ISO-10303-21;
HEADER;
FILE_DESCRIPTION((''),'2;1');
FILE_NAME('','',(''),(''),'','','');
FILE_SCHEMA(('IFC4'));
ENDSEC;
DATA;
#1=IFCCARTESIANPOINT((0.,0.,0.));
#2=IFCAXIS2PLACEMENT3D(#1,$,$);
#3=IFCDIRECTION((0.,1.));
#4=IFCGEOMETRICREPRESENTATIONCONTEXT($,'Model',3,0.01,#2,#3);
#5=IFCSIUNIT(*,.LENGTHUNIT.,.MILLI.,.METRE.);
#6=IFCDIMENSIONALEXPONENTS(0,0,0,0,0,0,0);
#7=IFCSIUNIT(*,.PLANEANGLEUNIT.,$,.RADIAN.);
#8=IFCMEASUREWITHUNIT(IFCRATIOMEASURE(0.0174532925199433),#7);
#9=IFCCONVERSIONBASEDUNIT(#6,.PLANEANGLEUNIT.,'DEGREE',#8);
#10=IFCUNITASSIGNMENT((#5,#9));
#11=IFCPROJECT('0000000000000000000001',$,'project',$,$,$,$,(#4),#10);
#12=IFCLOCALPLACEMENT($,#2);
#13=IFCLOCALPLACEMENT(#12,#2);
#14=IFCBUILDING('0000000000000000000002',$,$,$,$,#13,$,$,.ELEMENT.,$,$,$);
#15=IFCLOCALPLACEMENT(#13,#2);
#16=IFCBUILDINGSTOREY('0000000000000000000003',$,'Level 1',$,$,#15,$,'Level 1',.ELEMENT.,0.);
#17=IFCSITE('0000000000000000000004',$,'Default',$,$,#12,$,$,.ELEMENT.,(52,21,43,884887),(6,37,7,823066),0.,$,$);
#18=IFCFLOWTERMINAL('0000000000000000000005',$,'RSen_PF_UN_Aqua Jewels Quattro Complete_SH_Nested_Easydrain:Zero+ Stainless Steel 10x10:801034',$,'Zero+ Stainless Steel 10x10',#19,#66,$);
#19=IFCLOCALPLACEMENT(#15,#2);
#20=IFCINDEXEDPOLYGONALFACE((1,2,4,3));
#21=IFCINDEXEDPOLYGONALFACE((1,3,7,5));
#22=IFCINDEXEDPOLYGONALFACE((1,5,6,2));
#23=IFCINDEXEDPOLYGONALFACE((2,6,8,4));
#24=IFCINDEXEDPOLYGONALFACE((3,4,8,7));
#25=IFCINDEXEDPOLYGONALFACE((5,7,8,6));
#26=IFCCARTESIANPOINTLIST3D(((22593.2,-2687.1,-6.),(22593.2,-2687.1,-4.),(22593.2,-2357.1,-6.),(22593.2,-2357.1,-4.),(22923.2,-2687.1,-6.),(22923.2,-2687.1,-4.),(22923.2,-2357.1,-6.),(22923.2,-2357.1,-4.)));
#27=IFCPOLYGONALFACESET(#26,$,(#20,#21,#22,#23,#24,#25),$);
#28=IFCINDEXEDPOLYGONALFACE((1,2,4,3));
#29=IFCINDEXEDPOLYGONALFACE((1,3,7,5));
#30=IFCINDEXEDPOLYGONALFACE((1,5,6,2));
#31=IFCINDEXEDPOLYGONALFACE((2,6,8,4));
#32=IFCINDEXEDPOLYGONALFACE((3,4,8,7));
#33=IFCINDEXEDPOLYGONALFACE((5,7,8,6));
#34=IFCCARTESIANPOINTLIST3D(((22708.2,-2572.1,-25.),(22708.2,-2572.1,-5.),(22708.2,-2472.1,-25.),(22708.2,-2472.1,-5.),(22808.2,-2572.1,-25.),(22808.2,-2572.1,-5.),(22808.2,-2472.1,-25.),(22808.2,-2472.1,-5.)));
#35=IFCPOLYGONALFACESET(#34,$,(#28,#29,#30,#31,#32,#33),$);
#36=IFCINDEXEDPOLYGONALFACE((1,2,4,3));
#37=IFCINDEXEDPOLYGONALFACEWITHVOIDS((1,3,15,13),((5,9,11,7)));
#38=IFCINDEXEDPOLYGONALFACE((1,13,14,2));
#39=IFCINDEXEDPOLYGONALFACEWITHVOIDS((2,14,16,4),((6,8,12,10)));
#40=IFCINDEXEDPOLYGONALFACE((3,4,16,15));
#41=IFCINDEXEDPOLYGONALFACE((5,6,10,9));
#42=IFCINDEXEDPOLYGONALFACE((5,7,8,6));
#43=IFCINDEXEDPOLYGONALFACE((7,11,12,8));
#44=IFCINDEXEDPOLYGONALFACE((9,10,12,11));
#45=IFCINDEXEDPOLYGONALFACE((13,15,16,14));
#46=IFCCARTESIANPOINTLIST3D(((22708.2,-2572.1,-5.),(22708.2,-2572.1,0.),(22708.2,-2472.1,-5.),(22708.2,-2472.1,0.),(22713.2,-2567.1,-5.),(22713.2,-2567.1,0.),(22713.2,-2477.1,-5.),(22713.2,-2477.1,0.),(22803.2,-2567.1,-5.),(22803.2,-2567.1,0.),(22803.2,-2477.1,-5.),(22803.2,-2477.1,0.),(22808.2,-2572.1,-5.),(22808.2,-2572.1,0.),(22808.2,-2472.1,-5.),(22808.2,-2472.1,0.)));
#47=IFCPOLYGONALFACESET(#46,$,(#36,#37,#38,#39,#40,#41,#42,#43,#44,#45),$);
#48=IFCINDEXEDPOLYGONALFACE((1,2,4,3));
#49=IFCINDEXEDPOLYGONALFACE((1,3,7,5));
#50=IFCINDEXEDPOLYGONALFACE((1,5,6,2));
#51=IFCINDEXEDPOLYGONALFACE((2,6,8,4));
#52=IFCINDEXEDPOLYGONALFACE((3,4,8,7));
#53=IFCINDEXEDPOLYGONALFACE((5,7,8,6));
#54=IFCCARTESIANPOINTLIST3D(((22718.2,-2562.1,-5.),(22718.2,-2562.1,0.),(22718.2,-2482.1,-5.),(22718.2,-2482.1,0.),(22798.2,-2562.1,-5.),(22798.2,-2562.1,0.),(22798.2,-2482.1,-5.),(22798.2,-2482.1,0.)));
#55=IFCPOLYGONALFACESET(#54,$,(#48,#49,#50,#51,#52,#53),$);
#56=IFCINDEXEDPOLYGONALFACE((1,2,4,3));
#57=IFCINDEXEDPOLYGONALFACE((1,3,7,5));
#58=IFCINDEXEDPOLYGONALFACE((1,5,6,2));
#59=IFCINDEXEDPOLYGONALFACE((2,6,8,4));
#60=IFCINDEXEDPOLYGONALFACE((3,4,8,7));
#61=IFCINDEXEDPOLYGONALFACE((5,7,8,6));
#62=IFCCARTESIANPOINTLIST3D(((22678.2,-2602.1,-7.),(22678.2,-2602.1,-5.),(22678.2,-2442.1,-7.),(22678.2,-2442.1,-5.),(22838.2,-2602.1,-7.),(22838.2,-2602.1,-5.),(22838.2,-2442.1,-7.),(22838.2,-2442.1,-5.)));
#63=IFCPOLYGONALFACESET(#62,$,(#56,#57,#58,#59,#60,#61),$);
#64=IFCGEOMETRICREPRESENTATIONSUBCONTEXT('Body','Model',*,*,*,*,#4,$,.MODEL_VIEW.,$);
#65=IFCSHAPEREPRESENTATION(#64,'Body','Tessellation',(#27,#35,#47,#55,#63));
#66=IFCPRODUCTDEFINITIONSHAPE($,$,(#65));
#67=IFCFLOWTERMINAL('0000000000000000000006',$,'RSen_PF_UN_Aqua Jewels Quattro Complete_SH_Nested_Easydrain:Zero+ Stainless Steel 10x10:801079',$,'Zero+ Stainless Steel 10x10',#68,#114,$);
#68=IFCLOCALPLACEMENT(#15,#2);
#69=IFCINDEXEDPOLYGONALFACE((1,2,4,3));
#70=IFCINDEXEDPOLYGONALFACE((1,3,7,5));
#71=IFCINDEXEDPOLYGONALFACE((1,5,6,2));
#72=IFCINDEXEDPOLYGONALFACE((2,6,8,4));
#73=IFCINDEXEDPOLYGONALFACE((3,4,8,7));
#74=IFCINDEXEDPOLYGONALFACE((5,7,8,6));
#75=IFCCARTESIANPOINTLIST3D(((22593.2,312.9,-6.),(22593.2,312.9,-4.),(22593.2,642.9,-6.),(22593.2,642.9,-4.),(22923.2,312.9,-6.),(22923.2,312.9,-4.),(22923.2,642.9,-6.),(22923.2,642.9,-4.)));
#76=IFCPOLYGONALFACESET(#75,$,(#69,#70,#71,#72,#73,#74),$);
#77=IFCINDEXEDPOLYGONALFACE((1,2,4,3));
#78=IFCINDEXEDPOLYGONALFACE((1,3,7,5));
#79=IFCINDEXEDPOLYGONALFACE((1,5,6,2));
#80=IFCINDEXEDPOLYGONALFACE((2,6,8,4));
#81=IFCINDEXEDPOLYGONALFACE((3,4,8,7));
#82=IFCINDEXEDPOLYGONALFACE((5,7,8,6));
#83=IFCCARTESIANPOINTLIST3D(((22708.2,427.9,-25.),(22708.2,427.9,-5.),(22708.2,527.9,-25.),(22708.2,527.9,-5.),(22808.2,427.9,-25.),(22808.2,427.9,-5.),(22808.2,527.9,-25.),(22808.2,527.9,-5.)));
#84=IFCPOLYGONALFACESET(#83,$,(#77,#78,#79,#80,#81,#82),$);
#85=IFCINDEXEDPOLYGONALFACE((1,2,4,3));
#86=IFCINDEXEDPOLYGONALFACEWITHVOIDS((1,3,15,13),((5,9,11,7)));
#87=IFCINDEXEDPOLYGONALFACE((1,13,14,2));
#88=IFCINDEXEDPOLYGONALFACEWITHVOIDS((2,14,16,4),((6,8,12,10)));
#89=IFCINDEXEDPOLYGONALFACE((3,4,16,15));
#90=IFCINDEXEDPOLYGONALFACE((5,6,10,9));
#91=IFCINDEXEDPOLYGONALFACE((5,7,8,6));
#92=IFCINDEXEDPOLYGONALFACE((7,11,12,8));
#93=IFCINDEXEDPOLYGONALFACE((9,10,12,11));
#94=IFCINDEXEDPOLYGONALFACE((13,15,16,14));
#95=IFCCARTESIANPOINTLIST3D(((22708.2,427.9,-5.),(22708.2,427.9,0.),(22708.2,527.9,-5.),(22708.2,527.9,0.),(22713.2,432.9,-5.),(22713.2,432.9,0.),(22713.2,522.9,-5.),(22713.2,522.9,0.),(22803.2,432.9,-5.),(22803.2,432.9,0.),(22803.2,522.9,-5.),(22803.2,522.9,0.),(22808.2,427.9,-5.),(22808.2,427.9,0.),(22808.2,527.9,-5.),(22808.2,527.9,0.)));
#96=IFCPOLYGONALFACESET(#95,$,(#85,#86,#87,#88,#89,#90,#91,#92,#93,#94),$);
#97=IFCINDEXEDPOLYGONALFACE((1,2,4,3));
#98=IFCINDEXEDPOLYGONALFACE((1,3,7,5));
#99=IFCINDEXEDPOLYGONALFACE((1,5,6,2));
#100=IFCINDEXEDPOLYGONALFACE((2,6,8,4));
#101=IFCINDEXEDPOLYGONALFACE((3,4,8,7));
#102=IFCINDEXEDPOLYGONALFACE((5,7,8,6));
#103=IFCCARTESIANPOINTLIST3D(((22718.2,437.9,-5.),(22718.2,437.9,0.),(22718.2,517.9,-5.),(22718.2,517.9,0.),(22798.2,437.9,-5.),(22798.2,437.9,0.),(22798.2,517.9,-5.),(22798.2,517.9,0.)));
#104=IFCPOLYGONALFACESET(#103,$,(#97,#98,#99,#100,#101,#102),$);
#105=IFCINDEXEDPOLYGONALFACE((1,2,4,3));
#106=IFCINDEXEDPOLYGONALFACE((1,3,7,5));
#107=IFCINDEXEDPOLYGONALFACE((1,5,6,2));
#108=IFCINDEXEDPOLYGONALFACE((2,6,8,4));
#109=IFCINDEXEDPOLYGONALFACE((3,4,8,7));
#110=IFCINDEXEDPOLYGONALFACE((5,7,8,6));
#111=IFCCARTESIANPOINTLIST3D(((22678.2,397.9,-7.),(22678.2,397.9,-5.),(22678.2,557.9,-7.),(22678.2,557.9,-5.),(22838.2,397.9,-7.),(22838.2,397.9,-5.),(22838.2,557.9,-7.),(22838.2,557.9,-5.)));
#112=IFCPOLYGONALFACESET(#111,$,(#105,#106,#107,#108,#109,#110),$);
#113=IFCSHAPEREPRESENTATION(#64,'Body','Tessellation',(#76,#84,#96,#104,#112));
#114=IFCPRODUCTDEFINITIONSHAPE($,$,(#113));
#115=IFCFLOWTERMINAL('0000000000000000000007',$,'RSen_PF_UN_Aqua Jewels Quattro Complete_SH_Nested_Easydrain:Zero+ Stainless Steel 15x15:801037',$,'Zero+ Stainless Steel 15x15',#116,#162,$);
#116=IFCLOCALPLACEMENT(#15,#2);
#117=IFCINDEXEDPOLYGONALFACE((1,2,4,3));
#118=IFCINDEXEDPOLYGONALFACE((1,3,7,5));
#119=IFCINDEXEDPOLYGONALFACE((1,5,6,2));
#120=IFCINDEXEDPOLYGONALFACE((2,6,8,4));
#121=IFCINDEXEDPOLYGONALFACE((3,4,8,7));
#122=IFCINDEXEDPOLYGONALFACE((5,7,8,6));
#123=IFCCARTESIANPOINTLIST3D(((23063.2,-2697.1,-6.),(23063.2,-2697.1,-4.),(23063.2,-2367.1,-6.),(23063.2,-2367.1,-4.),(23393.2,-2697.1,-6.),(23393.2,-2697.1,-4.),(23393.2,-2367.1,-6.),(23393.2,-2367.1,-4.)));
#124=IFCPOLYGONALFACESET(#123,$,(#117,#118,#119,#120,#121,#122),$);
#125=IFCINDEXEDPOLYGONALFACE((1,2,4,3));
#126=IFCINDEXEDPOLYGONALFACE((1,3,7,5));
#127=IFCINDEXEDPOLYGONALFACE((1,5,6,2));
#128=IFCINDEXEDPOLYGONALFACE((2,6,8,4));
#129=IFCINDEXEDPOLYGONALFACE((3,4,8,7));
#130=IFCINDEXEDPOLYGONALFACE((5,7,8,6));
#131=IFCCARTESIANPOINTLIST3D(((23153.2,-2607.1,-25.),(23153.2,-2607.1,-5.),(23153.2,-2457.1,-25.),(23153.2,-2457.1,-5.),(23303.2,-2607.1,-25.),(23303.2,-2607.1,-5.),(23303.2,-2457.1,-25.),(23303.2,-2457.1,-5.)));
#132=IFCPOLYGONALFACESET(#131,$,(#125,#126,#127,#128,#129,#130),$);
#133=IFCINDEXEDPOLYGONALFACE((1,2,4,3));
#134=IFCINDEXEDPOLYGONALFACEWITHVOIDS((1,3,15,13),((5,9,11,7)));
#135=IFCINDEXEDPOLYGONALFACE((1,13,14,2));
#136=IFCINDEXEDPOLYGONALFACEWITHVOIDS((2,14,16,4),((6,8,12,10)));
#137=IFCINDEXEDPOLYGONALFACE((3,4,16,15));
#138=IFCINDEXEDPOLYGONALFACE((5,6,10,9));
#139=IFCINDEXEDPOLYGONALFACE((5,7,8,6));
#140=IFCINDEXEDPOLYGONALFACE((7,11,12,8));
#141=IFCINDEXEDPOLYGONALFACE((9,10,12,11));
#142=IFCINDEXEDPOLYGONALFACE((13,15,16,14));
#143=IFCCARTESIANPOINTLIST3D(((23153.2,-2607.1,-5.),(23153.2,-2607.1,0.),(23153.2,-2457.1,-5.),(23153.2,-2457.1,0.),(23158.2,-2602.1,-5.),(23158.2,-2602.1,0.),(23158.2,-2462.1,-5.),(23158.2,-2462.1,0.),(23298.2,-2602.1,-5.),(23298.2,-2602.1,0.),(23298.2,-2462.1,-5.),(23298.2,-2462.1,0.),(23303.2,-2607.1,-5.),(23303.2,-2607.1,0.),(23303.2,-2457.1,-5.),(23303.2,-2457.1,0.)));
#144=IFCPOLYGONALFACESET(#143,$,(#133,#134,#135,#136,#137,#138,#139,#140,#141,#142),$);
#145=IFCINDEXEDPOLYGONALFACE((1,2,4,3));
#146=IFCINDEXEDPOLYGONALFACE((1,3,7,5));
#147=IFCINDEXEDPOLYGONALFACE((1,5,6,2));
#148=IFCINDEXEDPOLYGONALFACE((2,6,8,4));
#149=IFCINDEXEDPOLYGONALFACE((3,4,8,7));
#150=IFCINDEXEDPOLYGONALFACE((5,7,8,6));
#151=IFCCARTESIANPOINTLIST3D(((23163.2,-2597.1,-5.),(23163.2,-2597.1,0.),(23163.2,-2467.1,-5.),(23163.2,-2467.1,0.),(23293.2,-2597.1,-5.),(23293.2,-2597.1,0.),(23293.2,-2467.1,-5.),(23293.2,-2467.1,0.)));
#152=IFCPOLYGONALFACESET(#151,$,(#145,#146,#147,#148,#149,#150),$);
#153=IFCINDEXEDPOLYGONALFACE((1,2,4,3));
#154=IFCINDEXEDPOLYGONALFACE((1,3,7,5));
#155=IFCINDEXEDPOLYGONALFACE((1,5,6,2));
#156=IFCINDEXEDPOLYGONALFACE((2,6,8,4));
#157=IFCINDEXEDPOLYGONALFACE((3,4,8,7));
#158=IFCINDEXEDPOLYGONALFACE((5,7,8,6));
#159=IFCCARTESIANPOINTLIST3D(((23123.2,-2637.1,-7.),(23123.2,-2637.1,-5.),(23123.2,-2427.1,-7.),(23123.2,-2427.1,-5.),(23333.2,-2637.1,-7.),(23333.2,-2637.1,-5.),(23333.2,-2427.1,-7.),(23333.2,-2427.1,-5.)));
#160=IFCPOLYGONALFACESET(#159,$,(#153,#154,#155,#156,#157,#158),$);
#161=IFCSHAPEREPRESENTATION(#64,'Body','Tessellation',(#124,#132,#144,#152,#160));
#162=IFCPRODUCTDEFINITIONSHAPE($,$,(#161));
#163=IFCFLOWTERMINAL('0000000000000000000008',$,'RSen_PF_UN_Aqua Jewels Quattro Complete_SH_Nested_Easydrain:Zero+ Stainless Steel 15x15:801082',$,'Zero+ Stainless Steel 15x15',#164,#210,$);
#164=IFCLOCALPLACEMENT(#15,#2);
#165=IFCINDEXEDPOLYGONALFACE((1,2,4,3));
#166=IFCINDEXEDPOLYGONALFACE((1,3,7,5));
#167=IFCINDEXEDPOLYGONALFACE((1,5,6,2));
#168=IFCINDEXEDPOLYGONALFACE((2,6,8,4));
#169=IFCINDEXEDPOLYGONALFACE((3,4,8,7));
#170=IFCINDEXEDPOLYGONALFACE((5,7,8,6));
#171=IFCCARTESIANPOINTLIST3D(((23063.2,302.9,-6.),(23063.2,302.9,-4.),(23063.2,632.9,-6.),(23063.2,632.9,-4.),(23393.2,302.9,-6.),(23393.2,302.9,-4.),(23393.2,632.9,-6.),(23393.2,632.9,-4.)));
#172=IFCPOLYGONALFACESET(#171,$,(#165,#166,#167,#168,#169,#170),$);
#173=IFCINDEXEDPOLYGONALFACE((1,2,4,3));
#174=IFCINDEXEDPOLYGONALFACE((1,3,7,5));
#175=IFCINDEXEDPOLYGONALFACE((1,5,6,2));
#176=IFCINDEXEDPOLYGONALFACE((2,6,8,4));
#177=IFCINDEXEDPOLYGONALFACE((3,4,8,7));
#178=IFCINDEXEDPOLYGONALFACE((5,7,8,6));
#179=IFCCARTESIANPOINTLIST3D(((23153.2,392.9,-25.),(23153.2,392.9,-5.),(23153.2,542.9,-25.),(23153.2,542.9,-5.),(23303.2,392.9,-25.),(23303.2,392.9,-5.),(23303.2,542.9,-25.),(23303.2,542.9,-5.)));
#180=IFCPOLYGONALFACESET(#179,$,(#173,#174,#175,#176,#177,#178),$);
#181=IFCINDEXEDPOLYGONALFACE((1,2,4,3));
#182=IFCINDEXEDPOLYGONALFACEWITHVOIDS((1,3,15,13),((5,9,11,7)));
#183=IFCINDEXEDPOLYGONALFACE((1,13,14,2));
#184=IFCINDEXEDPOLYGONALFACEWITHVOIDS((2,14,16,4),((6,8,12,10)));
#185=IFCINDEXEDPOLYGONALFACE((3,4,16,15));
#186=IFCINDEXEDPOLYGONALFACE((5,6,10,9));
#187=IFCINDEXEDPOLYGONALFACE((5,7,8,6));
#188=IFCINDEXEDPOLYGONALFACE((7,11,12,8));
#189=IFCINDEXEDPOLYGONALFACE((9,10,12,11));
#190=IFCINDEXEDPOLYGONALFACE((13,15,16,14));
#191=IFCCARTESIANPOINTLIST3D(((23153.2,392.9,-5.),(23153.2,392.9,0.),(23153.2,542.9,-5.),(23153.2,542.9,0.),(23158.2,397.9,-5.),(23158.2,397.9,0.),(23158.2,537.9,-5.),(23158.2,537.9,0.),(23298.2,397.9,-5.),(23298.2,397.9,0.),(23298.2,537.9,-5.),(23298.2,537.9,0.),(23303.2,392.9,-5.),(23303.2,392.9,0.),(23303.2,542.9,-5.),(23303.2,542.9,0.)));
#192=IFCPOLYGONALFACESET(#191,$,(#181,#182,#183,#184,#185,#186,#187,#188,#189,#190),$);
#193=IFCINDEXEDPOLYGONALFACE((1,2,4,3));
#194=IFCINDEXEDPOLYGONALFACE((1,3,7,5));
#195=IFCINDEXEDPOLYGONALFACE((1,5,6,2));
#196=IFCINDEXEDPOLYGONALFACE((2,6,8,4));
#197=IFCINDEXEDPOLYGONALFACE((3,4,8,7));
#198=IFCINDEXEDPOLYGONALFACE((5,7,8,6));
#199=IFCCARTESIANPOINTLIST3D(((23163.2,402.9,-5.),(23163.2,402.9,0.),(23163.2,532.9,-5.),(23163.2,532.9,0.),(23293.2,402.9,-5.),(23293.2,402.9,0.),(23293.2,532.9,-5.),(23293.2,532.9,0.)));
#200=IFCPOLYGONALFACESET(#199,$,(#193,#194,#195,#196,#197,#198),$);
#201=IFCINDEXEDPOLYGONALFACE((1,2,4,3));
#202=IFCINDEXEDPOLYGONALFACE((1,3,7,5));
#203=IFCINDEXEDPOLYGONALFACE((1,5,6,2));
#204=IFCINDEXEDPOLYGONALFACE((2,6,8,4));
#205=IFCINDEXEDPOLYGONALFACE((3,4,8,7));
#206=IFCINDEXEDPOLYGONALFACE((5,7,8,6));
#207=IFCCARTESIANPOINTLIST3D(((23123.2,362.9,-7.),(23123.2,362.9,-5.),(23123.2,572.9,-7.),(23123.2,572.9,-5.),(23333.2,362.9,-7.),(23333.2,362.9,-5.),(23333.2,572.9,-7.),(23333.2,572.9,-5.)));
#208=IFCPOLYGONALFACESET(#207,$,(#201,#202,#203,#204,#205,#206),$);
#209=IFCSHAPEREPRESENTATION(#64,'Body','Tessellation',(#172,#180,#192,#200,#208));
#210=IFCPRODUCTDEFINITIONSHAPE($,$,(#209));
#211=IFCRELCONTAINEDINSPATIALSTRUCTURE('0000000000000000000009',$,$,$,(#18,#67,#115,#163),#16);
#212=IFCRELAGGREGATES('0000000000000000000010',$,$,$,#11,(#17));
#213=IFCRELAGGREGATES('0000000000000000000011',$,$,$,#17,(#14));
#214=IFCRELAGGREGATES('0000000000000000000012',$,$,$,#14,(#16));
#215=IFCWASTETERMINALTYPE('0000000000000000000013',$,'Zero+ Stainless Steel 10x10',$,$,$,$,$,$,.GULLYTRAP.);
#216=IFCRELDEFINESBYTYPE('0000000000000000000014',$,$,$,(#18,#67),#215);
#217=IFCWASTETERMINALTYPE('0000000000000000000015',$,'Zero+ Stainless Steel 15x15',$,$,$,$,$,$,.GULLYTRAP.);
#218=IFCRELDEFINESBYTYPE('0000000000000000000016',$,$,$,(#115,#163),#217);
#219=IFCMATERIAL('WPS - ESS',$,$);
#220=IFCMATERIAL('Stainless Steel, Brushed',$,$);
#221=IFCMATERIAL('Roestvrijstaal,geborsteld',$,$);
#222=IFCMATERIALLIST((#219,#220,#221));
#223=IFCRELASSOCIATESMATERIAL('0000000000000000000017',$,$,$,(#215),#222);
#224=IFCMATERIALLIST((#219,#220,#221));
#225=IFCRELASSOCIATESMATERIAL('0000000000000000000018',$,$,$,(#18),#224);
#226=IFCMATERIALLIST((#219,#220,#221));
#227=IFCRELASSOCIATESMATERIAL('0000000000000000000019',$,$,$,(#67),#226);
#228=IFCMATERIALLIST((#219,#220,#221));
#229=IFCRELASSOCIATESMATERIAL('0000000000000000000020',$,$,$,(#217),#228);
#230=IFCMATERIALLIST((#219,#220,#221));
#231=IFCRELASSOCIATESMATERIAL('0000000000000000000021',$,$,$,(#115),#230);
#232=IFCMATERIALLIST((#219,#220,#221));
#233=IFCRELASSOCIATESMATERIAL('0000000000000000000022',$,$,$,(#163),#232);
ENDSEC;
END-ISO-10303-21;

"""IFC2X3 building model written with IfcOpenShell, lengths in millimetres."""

from ifc_helpers import new_model, entity, si_unit, converted_unit, direction, frame, frame_2d, origin, origin_2d_with_axis, place, context, subcontext, project, spatial, polyline, rectangle, outline, extrude, source, transform, mapped, material, material_list, type_object, type_shapes, element, save


model = new_model("IFC2X3")

# Units and contexts
model_context = context("Model", 3, precision=0.01, world=origin(), true_north=direction((0.0, 1.0)))
body_context = subcontext(model_context, "Body", "Model", "MODEL_VIEW")
ifc_project = project(units=[si_unit("LENGTHUNIT", "METRE", prefix="MILLI"), converted_unit("PLANEANGLEUNIT", "DEGREE", entity("IfcRatioMeasure", 0.0174532925199433), si_unit("PLANEANGLEUNIT", "RADIAN"), dimensions=[0, 0, 0, 0, 0, 0, 0])], contexts=[model_context])

# Site, building, storey
site_placement = place(None, origin())
site = spatial("IfcSite", under=ifc_project, at=site_placement, Name="Default", CompositionType="ELEMENT", RefLatitude=(52, 21, 43, 884887), RefLongitude=(6, 37, 7, 823066), RefElevation=0.0)
building_placement = place(site_placement, origin())
building = spatial("IfcBuilding", under=site, at=building_placement, CompositionType="ELEMENT")
storey_placement = place(building_placement, origin())
storey = spatial("IfcBuildingStorey", under=building, at=storey_placement, Name="Level 1", LongName="Level 1", CompositionType="ELEMENT", Elevation=0.0)

# Flow terminals
ifc_material_1 = material(Name="WPS - ESS")
ifc_material_2 = material(Name="Stainless Steel, Brushed")
ifc_material_3 = material(Name="Roestvrijstaal,geborsteld")
ifc_material_list_1 = material_list([ifc_material_1, ifc_material_2, ifc_material_3])
ifc_material_list_2 = material_list([ifc_material_1, ifc_material_2, ifc_material_3])
waste_terminal_type_1 = type_object("IfcWasteTerminalType", Name="Zero+ Stainless Steel 10x10", PredefinedType="GULLYTRAP", material=ifc_material_list_2)
shared_shape_1 = source(origin(), body_context, "Body", "SweptSolid", [
    extrude(rectangle(XDim=330.0, YDim=330.0, at=origin_2d_with_axis()), frame((0.0, 0.0, -6.0), z_axis=(0.0, 0.0, 1.0), x_axis=(-1.0, 0.0, 0.0)), (0.0, 0.0, 1.0), 2.0),
    extrude(rectangle(XDim=100.0, YDim=100.0, at=origin_2d_with_axis()), frame((0.0, 0.0, -25.0), z_axis=(0.0, 0.0, 1.0), x_axis=(-1.0, 0.0, 0.0)), (0.0, 0.0, 1.0), 20.0),
    extrude(outline(polyline([(-50.0, -50.0), (50.0, -50.0), (50.0, 50.0), (-50.0, 50.0), (-50.0, -50.0)]), holes=[polyline([(-45.0, -45.0), (-45.0, 45.0), (45.0, 45.0), (45.0, -45.0), (-45.0, -45.0)])]), frame((0.0, 0.0, -5.0), z_axis=(0.0, 0.0, 1.0), x_axis=(-1.0, 0.0, 0.0)), (0.0, 0.0, 1.0), 5.0),
    extrude(rectangle(XDim=80.0, YDim=80.0, at=origin_2d_with_axis()), frame((0.0, 0.0, -5.0), z_axis=(0.0, 0.0, 1.0), x_axis=(-1.0, 0.0, 0.0)), (0.0, 0.0, 1.0), 5.0),
    extrude(rectangle(XDim=160.0, YDim=160.0, at=origin_2d_with_axis()), frame((0.0, 0.0, -7.0), z_axis=(0.0, 0.0, 1.0), x_axis=(-1.0, 0.0, 0.0)), (0.0, 0.0, 1.0), 2.0),
])
type_shapes(waste_terminal_type_1, [shared_shape_1])
flow_terminal_1_placement = place(storey_placement, frame((22758.2, -2522.1, 0.0)))
element("IfcFlowTerminal", 1, at=flow_terminal_1_placement, inside=storey, type_object=waste_terminal_type_1, material=ifc_material_list_1, Name="RSen_PF_UN_Aqua Jewels Quattro Complete_SH_Nested_Easydrain:Zero+ Stainless Steel 10x10:801034", ObjectType="Zero+ Stainless Steel 10x10", context=body_context, shape_type="MappedRepresentation", body=[
    mapped(shared_shape_1, transform((0.0, 0.0, 0.0), scale=1.0)),
])
ifc_material_list_3 = material_list([ifc_material_1, ifc_material_2, ifc_material_3])
flow_terminal_2_placement = place(storey_placement, frame((22758.2, 477.9, 0.0)))
element("IfcFlowTerminal", 2, at=flow_terminal_2_placement, inside=storey, type_object=waste_terminal_type_1, material=ifc_material_list_3, Name="RSen_PF_UN_Aqua Jewels Quattro Complete_SH_Nested_Easydrain:Zero+ Stainless Steel 10x10:801079", ObjectType="Zero+ Stainless Steel 10x10", context=body_context, shape_type="MappedRepresentation", body=[
    mapped(shared_shape_1, transform((0.0, 0.0, 0.0), scale=1.0)),
])
ifc_material_list_4 = material_list([ifc_material_1, ifc_material_2, ifc_material_3])
ifc_material_list_5 = material_list([ifc_material_1, ifc_material_2, ifc_material_3])
waste_terminal_type_2 = type_object("IfcWasteTerminalType", Name="Zero+ Stainless Steel 15x15", PredefinedType="GULLYTRAP", material=ifc_material_list_5)
shared_shape_2 = source(origin(), body_context, "Body", "SweptSolid", [
    extrude(rectangle(XDim=330.0, YDim=330.0, at=origin_2d_with_axis()), frame((5.0, -10.0, -6.0), z_axis=(0.0, 0.0, 1.0), x_axis=(-1.0, 0.0, 0.0)), (0.0, 0.0, 1.0), 2.0),
    extrude(rectangle(XDim=150.0, YDim=150.0, at=origin_2d_with_axis()), frame((5.0, -10.0, -25.0), z_axis=(0.0, 0.0, 1.0), x_axis=(-1.0, 0.0, 0.0)), (0.0, 0.0, 1.0), 20.0),
    extrude(outline(polyline([(-75.0, -75.0), (75.0, -75.0), (75.0, 75.0), (-75.0, 75.0), (-75.0, -75.0)]), holes=[polyline([(-70.0, -70.0), (-70.0, 70.0), (70.0, 70.0), (70.0, -70.0), (-70.0, -70.0)])]), frame((5.0, -10.0, -5.0), z_axis=(0.0, 0.0, 1.0), x_axis=(-1.0, 0.0, 0.0)), (0.0, 0.0, 1.0), 5.0),
    extrude(rectangle(XDim=130.0, YDim=130.0, at=frame_2d((0.0, 0.0), x_axis=(1.0, 0.0))), frame((5.0, -10.0, -5.0), z_axis=(0.0, 0.0, 1.0), x_axis=(-1.0, 0.0, 0.0)), (0.0, 0.0, 1.0), 5.0),
    extrude(rectangle(XDim=210.0, YDim=210.0, at=origin_2d_with_axis()), frame((5.0, -10.0, -7.0), z_axis=(0.0, 0.0, 1.0), x_axis=(-1.0, 0.0, 0.0)), (0.0, 0.0, 1.0), 2.0),
])
type_shapes(waste_terminal_type_2, [shared_shape_2])
flow_terminal_3_placement = place(storey_placement, frame((23223.2, -2522.1, 0.0)))
element("IfcFlowTerminal", 3, at=flow_terminal_3_placement, inside=storey, type_object=waste_terminal_type_2, material=ifc_material_list_4, Name="RSen_PF_UN_Aqua Jewels Quattro Complete_SH_Nested_Easydrain:Zero+ Stainless Steel 15x15:801037", ObjectType="Zero+ Stainless Steel 15x15", context=body_context, shape_type="MappedRepresentation", body=[
    mapped(shared_shape_2, transform((0.0, 0.0, 0.0), scale=1.0)),
])
ifc_material_list_6 = material_list([ifc_material_1, ifc_material_2, ifc_material_3])
flow_terminal_4_placement = place(storey_placement, frame((23223.2, 477.9, 0.0)))
element("IfcFlowTerminal", 4, at=flow_terminal_4_placement, inside=storey, type_object=waste_terminal_type_2, material=ifc_material_list_6, Name="RSen_PF_UN_Aqua Jewels Quattro Complete_SH_Nested_Easydrain:Zero+ Stainless Steel 15x15:801082", ObjectType="Zero+ Stainless Steel 15x15", context=body_context, shape_type="MappedRepresentation", body=[
    mapped(shared_shape_2, transform((0.0, 0.0, 0.0), scale=1.0)),
])

save(model, "model.ifc")
